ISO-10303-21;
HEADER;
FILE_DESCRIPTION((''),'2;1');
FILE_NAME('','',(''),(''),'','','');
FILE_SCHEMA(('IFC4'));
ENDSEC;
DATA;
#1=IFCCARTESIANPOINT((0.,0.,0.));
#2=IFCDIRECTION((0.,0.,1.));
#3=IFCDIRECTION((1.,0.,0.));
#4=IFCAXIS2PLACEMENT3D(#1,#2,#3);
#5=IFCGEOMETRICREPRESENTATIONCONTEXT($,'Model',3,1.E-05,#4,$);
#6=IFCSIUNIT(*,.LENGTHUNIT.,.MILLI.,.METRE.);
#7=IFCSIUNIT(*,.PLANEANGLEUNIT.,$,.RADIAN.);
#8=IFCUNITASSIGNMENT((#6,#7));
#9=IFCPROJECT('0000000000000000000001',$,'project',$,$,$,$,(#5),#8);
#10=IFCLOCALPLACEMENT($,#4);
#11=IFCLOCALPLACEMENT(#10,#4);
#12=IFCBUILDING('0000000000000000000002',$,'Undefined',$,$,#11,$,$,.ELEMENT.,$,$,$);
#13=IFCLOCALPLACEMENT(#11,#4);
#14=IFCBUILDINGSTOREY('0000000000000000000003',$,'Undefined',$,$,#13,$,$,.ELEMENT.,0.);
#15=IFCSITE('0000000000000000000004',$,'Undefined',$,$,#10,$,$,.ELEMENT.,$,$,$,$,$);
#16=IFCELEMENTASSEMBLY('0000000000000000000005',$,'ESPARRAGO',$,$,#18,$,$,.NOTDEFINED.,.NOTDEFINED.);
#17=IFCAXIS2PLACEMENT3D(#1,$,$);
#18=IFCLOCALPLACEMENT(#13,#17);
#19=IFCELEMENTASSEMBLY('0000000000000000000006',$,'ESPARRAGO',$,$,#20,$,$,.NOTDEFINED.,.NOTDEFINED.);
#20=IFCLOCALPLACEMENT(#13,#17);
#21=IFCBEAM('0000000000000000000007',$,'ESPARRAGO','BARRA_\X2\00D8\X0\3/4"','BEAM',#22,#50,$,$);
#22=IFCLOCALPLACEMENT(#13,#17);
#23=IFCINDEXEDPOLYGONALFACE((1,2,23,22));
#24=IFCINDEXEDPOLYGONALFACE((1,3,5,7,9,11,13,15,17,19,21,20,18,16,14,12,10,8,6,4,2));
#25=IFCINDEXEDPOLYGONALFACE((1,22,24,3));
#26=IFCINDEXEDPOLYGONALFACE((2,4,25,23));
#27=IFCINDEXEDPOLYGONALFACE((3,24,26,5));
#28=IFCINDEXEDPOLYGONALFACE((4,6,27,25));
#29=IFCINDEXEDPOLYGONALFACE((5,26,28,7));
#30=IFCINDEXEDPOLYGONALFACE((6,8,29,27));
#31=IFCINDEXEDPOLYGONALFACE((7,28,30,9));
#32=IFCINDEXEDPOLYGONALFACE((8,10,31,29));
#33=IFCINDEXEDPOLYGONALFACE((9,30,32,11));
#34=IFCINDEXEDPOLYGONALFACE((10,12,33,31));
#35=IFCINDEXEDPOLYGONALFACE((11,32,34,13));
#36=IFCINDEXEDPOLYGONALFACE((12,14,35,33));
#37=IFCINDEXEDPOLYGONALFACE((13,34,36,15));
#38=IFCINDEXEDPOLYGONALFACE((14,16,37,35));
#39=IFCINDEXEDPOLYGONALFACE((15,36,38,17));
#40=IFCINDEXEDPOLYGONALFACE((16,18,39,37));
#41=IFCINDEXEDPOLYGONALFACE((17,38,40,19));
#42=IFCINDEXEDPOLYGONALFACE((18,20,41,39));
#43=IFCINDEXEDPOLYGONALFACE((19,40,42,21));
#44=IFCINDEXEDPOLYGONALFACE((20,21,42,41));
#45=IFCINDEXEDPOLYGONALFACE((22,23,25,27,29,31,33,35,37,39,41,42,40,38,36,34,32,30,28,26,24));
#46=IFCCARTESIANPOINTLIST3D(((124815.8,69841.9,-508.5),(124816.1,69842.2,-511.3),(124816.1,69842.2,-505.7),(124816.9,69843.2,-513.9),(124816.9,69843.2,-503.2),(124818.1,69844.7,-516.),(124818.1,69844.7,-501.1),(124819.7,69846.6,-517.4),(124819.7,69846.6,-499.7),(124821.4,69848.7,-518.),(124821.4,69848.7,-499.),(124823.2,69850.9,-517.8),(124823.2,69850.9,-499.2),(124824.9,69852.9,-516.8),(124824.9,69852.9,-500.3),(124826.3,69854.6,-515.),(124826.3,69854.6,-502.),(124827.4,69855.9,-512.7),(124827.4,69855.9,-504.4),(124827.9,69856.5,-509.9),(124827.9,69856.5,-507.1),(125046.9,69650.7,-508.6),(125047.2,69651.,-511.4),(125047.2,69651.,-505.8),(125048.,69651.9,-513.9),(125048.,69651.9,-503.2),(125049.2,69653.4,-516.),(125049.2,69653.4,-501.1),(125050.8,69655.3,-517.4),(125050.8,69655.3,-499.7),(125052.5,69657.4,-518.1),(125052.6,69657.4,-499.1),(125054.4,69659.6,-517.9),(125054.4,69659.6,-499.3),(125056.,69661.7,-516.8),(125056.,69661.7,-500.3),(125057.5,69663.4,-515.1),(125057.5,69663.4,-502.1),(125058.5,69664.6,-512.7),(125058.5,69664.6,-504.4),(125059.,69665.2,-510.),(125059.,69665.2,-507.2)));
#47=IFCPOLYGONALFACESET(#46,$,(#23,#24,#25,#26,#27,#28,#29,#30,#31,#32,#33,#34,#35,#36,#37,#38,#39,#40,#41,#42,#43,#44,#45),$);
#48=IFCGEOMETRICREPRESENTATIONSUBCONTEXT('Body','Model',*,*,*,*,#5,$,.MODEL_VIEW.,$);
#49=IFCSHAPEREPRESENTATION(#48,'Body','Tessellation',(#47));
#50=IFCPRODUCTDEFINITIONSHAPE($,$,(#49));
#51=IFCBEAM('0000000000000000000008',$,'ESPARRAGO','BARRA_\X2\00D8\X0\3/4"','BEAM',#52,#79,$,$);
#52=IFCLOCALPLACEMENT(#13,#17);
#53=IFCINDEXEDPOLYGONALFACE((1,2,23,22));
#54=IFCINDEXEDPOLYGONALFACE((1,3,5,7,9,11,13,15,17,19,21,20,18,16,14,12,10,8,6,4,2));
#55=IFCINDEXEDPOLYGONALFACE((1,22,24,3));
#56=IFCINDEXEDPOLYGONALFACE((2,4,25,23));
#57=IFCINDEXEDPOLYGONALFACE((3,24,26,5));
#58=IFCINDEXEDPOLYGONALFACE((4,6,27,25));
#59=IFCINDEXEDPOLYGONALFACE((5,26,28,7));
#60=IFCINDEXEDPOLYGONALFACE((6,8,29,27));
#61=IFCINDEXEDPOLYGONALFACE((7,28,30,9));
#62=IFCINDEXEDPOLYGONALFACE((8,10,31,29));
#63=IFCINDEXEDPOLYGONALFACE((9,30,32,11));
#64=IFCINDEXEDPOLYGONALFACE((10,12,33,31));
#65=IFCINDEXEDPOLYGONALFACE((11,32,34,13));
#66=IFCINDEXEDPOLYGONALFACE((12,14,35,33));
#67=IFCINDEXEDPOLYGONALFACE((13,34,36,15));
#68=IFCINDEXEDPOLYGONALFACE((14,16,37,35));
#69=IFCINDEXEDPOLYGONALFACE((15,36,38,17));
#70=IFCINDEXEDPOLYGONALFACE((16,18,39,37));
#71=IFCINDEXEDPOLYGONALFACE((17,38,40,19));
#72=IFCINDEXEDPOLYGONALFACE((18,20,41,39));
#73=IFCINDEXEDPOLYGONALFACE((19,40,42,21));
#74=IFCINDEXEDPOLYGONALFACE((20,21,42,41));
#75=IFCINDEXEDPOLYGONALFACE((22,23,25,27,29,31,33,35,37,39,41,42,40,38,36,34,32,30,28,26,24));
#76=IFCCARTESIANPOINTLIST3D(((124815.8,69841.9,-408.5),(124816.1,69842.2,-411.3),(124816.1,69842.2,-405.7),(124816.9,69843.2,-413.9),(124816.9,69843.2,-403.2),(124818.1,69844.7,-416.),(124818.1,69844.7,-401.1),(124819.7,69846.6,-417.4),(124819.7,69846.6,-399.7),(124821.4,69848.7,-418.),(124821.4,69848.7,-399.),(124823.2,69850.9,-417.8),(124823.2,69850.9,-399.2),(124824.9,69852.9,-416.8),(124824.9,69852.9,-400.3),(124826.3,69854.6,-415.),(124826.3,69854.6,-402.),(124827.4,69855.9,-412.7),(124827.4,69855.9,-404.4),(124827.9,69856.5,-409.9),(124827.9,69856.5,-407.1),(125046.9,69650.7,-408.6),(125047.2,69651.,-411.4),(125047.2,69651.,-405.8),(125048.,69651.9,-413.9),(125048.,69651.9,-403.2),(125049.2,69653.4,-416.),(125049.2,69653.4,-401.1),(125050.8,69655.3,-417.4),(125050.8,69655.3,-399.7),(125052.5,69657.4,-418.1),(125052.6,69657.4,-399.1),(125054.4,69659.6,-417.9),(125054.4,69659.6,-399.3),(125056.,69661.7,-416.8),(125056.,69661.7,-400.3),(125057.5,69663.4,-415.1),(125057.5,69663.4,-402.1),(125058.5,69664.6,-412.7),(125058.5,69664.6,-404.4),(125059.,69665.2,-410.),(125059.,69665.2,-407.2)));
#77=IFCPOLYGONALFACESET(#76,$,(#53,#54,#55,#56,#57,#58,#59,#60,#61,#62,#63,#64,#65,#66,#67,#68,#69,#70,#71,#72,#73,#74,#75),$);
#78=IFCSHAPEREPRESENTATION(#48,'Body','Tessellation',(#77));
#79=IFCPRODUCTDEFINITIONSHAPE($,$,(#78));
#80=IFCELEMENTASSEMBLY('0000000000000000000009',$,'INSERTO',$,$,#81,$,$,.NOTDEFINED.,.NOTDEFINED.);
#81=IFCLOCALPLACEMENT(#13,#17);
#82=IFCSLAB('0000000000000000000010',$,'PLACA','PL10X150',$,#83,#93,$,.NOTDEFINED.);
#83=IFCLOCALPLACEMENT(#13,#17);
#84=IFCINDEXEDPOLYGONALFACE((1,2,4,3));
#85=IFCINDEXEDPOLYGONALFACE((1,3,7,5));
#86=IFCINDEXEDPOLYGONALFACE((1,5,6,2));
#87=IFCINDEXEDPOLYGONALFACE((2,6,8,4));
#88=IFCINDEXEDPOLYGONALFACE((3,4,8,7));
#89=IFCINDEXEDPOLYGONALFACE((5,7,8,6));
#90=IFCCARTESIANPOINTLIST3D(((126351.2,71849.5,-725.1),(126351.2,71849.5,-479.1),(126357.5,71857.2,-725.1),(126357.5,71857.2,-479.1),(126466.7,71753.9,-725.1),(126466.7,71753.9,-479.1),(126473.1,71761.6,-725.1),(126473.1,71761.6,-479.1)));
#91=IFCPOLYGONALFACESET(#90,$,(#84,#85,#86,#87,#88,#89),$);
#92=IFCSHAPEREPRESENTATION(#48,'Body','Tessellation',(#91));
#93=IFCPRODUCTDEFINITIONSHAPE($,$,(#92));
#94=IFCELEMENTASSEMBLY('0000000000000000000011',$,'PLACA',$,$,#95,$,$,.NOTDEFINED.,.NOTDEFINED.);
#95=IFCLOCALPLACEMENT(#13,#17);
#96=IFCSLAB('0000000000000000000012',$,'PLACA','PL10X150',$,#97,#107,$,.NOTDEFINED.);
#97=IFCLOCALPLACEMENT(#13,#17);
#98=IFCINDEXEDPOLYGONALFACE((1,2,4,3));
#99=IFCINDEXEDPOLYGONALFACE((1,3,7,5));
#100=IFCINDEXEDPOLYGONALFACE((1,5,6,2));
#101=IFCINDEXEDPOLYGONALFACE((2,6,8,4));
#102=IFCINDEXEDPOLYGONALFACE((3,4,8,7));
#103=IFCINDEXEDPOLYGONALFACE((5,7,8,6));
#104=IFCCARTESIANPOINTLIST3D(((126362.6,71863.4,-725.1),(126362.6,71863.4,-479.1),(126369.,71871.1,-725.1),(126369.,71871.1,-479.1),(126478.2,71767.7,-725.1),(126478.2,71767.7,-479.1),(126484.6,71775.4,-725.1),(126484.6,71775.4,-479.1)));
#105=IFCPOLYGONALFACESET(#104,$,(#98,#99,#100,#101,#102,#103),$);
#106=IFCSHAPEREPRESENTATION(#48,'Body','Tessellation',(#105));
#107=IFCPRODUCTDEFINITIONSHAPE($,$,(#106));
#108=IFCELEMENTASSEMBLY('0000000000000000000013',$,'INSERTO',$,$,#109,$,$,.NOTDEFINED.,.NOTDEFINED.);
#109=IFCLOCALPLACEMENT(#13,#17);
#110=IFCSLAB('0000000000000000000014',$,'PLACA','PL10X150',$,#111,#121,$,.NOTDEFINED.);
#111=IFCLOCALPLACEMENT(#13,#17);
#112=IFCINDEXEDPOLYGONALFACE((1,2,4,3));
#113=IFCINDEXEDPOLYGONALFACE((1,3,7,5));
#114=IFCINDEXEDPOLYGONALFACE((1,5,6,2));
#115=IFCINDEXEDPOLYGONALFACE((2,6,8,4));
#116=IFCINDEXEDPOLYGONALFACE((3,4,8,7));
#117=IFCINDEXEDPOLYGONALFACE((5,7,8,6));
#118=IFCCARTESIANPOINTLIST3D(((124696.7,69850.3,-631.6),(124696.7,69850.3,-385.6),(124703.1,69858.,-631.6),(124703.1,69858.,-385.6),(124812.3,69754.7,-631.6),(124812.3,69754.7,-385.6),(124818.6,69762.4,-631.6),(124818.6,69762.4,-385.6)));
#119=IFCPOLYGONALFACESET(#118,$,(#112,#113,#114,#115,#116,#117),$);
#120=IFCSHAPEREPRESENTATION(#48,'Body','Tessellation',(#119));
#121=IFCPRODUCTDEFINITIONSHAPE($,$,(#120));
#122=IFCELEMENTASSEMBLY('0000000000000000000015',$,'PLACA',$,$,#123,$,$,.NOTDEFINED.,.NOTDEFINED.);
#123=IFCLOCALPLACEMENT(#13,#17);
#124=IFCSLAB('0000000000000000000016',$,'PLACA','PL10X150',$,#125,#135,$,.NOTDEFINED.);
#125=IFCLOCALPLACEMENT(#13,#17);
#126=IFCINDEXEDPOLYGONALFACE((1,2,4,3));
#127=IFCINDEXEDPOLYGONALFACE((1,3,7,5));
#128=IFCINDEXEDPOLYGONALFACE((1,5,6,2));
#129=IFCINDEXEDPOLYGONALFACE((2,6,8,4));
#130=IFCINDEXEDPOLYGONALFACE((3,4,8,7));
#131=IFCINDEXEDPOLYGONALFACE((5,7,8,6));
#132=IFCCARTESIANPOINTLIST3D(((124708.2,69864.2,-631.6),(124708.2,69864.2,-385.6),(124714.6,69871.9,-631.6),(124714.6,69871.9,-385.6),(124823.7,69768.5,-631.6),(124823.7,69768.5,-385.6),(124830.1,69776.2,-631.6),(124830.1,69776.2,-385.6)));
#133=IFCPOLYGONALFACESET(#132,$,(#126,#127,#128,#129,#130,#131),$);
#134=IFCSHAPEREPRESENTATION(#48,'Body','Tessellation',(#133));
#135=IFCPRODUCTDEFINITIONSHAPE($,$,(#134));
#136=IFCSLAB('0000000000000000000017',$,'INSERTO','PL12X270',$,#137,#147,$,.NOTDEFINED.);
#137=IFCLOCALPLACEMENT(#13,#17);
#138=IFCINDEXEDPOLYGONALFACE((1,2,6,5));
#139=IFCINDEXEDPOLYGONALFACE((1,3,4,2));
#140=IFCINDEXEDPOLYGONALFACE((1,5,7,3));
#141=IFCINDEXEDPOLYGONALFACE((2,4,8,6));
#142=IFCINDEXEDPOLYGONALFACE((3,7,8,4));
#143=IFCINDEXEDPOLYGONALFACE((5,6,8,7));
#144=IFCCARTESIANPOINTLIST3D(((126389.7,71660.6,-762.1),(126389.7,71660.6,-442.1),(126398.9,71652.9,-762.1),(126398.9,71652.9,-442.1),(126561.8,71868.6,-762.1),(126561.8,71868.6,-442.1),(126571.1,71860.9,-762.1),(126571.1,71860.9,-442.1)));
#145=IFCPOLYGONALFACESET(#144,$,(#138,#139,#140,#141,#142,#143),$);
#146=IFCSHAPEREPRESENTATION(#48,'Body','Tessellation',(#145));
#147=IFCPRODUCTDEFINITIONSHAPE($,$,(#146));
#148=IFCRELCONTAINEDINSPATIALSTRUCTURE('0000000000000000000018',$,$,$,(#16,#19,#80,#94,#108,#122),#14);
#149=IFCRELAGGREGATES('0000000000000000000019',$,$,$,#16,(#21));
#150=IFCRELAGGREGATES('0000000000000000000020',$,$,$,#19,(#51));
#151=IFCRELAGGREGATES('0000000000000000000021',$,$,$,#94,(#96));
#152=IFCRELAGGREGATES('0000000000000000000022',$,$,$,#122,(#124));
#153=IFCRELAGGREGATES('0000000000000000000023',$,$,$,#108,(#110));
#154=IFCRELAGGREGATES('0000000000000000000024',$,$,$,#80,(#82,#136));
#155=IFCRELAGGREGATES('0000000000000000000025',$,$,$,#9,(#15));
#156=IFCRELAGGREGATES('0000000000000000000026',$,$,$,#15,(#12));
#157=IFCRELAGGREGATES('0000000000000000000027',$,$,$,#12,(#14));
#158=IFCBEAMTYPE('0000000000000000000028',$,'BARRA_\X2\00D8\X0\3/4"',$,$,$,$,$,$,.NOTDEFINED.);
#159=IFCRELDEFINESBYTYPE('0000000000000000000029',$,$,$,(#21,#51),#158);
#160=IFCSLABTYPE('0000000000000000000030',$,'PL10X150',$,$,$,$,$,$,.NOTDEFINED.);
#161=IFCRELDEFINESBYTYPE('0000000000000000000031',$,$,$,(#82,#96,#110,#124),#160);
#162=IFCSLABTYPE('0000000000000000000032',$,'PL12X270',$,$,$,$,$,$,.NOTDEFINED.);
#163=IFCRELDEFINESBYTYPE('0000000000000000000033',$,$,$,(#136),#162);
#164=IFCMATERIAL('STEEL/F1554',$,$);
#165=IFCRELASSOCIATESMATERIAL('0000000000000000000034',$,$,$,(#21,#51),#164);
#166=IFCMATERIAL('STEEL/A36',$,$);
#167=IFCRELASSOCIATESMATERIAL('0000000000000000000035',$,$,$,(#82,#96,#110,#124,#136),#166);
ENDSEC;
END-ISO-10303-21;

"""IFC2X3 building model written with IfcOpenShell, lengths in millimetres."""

from ifc_helpers import new_model, si_unit, frame, origin_with_axes, origin_2d_with_axis, place, context, subcontext, project, spatial, polyline, circle, outline, extrude, material, type_object, element, aggregate, save


model = new_model("IFC2X3")

# Units and contexts
model_context = context("Model", 3, precision=1e-05, world=origin_with_axes())
body_context = subcontext(model_context, "Body", "Model", "MODEL_VIEW")
ifc_project = project(units=[si_unit("LENGTHUNIT", "METRE", prefix="MILLI"), si_unit("PLANEANGLEUNIT", "RADIAN")], contexts=[model_context])

# Site, building, storey
site_placement = place(None, origin_with_axes())
site = spatial("IfcSite", under=ifc_project, at=site_placement, Name="Undefined", CompositionType="ELEMENT")
building_placement = place(site_placement, origin_with_axes())
building = spatial("IfcBuilding", under=site, at=building_placement, Name="Undefined", CompositionType="ELEMENT")
storey_placement = place(building_placement, origin_with_axes())
storey = spatial("IfcBuildingStorey", under=building, at=storey_placement, Name="Undefined", CompositionType="ELEMENT", Elevation=0.0)

# Element assemblies
assembly_1_placement = place(storey_placement, origin_with_axes())
assembly_1 = element("IfcElementAssembly", 1, at=assembly_1_placement, inside=storey, Name="ESPARRAGO", AssemblyPlace="NOTDEFINED", PredefinedType="NOTDEFINED")
assembly_2_placement = place(storey_placement, origin_with_axes())
assembly_2 = element("IfcElementAssembly", 2, at=assembly_2_placement, inside=storey, Name="ESPARRAGO", AssemblyPlace="NOTDEFINED", PredefinedType="NOTDEFINED")

# Beams
ifc_material_1 = material(Name="STEEL/F1554")
beam_type_1 = type_object("IfcBeamType", Name="BARRA_Ø3/4\"", PredefinedType="NOTDEFINED")
beam_1_placement = place(assembly_1_placement, frame((124821.9, 69849.3, -508.5), z_axis=(0.000162, -0.000134, 1.0), x_axis=(0.770403, -0.637558, -0.000211)))
beam_1 = element("IfcBeam", 3, at=beam_1_placement, type_object=beam_type_1, material=ifc_material_1, Name="ESPARRAGO", Description="BARRA_Ø3/4\"", ObjectType="BEAM", context=body_context, shape_type="SweptSolid", body=[
    extrude(circle(Radius=9.5, at=origin_2d_with_axis()), frame((300.0, 0.0, 0.0), z_axis=(-1.0, 0.0, 0.0), x_axis=(0.0, -1.0, 0.0)), (0.0, 0.0, 1.0), 300.0),
])
aggregate(assembly_1, [beam_1])
beam_2_placement = place(assembly_2_placement, frame((124821.9, 69849.3, -408.5), z_axis=(0.000162, -0.000134, 1.0), x_axis=(0.770403, -0.637558, -0.000211)))
beam_2 = element("IfcBeam", 4, at=beam_2_placement, type_object=beam_type_1, material=ifc_material_1, Name="ESPARRAGO", Description="BARRA_Ø3/4\"", ObjectType="BEAM", context=body_context, shape_type="SweptSolid", body=[
    extrude(circle(Radius=9.5, at=origin_2d_with_axis()), frame((300.0, 0.0, 0.0), z_axis=(-1.0, 0.0, 0.0), x_axis=(0.0, -1.0, 0.0)), (0.0, 0.0, 1.0), 300.0),
])
aggregate(assembly_2, [beam_2])

# Element assemblies, slabs
assembly_3_placement = place(storey_placement, origin_with_axes())
assembly_3 = element("IfcElementAssembly", 5, at=assembly_3_placement, inside=storey, Name="INSERTO", AssemblyPlace="NOTDEFINED", PredefinedType="NOTDEFINED")
ifc_material_2 = material(Name="STEEL/A36")
slab_type_1 = type_object("IfcSlabType", Name="PL10X150", PredefinedType="NOTDEFINED")
slab_1_placement = place(assembly_3_placement, frame((126469.9, 71757.7, -479.1), z_axis=(-0.637561, -0.7704, 0.0), x_axis=(-0.7704, 0.637561, 0.0)))
slab_1 = element("IfcSlab", 6, at=slab_1_placement, type_object=slab_type_1, material=ifc_material_2, Name="PLACA", Description="PL10X150", PredefinedType="NOTDEFINED", context=body_context, shape_type="SweptSolid", body=[
    extrude(outline(polyline([(0.0, 0.0), (150.0, 0.0), (150.0, 246.0), (0.0, 246.0), (0.0, 0.0)])), frame((0.0, 0.0, -5.0), z_axis=(0.0, 0.0, 1.0), x_axis=(1.0, 0.0, 0.0)), (0.0, 0.0, 1.0), 10.0),
])
assembly_4_placement = place(storey_placement, origin_with_axes())
assembly_4 = element("IfcElementAssembly", 7, at=assembly_4_placement, inside=storey, Name="PLACA", AssemblyPlace="NOTDEFINED", PredefinedType="NOTDEFINED")
slab_2_placement = place(assembly_4_placement, frame((126481.4, 71771.6, -479.1), z_axis=(-0.637561, -0.7704, 0.0), x_axis=(-0.7704, 0.637561, 0.0)))
slab_2 = element("IfcSlab", 8, at=slab_2_placement, type_object=slab_type_1, material=ifc_material_2, Name="PLACA", Description="PL10X150", PredefinedType="NOTDEFINED", context=body_context, shape_type="SweptSolid", body=[
    extrude(outline(polyline([(0.0, 0.0), (150.0, 0.0), (150.0, 246.0), (0.0, 246.0), (0.0, 0.0)])), frame((0.0, 0.0, -5.0), z_axis=(0.0, 0.0, 1.0), x_axis=(1.0, 0.0, 0.0)), (0.0, 0.0, 1.0), 10.0),
])
aggregate(assembly_4, [slab_2])
assembly_5_placement = place(storey_placement, origin_with_axes())
assembly_5 = element("IfcElementAssembly", 9, at=assembly_5_placement, inside=storey, Name="INSERTO", AssemblyPlace="NOTDEFINED", PredefinedType="NOTDEFINED")
slab_3_placement = place(assembly_5_placement, frame((124815.5, 69758.5, -385.6), z_axis=(-0.637561, -0.7704, 0.0), x_axis=(-0.7704, 0.637561, 0.0)))
slab_3 = element("IfcSlab", 10, at=slab_3_placement, type_object=slab_type_1, material=ifc_material_2, Name="PLACA", Description="PL10X150", PredefinedType="NOTDEFINED", context=body_context, shape_type="SweptSolid", body=[
    extrude(outline(polyline([(0.0, 0.0), (150.0, 0.0), (150.0, 246.0), (0.0, 246.0), (0.0, 0.0)])), frame((0.0, 0.0, -5.0), z_axis=(0.0, 0.0, 1.0), x_axis=(1.0, 0.0, 0.0)), (0.0, 0.0, 1.0), 10.0),
])
assembly_6_placement = place(storey_placement, origin_with_axes())
assembly_6 = element("IfcElementAssembly", 11, at=assembly_6_placement, inside=storey, Name="PLACA", AssemblyPlace="NOTDEFINED", PredefinedType="NOTDEFINED")
slab_4_placement = place(assembly_6_placement, frame((124826.9, 69772.4, -385.6), z_axis=(-0.637561, -0.7704, 0.0), x_axis=(-0.7704, 0.637561, 0.0)))
slab_4 = element("IfcSlab", 12, at=slab_4_placement, type_object=slab_type_1, material=ifc_material_2, Name="PLACA", Description="PL10X150", PredefinedType="NOTDEFINED", context=body_context, shape_type="SweptSolid", body=[
    extrude(outline(polyline([(0.0, 0.0), (150.0, 0.0), (150.0, 246.0), (0.0, 246.0), (0.0, 0.0)])), frame((0.0, 0.0, -5.0), z_axis=(0.0, 0.0, 1.0), x_axis=(1.0, 0.0, 0.0)), (0.0, 0.0, 1.0), 10.0),
])
aggregate(assembly_6, [slab_4])

# Slab
slab_type_2 = type_object("IfcSlabType", Name="PL12X270", PredefinedType="NOTDEFINED")
slab_5_placement = place(assembly_3_placement, frame((126394.3, 71656.7, -442.1), z_axis=(-0.7704, 0.637561, 0.0), x_axis=(0.637561, 0.7704, -0.000001)))
slab_5 = element("IfcSlab", 13, at=slab_5_placement, type_object=slab_type_2, material=ifc_material_2, Name="INSERTO", Description="PL12X270", PredefinedType="NOTDEFINED", context=body_context, shape_type="SweptSolid", body=[
    extrude(outline(polyline([(0.0, 0.0), (270.0, 0.0), (270.0, 320.0), (0.0, 320.0), (0.0, 0.0)])), frame((0.0, 0.0, -6.0), z_axis=(0.0, 0.0, 1.0), x_axis=(1.0, 0.0, 0.0)), (0.0, 0.0, 1.0), 12.0),
])

aggregate(assembly_5, [slab_3])
aggregate(assembly_3, [slab_1, slab_5])

save(model, "model.ifc")
